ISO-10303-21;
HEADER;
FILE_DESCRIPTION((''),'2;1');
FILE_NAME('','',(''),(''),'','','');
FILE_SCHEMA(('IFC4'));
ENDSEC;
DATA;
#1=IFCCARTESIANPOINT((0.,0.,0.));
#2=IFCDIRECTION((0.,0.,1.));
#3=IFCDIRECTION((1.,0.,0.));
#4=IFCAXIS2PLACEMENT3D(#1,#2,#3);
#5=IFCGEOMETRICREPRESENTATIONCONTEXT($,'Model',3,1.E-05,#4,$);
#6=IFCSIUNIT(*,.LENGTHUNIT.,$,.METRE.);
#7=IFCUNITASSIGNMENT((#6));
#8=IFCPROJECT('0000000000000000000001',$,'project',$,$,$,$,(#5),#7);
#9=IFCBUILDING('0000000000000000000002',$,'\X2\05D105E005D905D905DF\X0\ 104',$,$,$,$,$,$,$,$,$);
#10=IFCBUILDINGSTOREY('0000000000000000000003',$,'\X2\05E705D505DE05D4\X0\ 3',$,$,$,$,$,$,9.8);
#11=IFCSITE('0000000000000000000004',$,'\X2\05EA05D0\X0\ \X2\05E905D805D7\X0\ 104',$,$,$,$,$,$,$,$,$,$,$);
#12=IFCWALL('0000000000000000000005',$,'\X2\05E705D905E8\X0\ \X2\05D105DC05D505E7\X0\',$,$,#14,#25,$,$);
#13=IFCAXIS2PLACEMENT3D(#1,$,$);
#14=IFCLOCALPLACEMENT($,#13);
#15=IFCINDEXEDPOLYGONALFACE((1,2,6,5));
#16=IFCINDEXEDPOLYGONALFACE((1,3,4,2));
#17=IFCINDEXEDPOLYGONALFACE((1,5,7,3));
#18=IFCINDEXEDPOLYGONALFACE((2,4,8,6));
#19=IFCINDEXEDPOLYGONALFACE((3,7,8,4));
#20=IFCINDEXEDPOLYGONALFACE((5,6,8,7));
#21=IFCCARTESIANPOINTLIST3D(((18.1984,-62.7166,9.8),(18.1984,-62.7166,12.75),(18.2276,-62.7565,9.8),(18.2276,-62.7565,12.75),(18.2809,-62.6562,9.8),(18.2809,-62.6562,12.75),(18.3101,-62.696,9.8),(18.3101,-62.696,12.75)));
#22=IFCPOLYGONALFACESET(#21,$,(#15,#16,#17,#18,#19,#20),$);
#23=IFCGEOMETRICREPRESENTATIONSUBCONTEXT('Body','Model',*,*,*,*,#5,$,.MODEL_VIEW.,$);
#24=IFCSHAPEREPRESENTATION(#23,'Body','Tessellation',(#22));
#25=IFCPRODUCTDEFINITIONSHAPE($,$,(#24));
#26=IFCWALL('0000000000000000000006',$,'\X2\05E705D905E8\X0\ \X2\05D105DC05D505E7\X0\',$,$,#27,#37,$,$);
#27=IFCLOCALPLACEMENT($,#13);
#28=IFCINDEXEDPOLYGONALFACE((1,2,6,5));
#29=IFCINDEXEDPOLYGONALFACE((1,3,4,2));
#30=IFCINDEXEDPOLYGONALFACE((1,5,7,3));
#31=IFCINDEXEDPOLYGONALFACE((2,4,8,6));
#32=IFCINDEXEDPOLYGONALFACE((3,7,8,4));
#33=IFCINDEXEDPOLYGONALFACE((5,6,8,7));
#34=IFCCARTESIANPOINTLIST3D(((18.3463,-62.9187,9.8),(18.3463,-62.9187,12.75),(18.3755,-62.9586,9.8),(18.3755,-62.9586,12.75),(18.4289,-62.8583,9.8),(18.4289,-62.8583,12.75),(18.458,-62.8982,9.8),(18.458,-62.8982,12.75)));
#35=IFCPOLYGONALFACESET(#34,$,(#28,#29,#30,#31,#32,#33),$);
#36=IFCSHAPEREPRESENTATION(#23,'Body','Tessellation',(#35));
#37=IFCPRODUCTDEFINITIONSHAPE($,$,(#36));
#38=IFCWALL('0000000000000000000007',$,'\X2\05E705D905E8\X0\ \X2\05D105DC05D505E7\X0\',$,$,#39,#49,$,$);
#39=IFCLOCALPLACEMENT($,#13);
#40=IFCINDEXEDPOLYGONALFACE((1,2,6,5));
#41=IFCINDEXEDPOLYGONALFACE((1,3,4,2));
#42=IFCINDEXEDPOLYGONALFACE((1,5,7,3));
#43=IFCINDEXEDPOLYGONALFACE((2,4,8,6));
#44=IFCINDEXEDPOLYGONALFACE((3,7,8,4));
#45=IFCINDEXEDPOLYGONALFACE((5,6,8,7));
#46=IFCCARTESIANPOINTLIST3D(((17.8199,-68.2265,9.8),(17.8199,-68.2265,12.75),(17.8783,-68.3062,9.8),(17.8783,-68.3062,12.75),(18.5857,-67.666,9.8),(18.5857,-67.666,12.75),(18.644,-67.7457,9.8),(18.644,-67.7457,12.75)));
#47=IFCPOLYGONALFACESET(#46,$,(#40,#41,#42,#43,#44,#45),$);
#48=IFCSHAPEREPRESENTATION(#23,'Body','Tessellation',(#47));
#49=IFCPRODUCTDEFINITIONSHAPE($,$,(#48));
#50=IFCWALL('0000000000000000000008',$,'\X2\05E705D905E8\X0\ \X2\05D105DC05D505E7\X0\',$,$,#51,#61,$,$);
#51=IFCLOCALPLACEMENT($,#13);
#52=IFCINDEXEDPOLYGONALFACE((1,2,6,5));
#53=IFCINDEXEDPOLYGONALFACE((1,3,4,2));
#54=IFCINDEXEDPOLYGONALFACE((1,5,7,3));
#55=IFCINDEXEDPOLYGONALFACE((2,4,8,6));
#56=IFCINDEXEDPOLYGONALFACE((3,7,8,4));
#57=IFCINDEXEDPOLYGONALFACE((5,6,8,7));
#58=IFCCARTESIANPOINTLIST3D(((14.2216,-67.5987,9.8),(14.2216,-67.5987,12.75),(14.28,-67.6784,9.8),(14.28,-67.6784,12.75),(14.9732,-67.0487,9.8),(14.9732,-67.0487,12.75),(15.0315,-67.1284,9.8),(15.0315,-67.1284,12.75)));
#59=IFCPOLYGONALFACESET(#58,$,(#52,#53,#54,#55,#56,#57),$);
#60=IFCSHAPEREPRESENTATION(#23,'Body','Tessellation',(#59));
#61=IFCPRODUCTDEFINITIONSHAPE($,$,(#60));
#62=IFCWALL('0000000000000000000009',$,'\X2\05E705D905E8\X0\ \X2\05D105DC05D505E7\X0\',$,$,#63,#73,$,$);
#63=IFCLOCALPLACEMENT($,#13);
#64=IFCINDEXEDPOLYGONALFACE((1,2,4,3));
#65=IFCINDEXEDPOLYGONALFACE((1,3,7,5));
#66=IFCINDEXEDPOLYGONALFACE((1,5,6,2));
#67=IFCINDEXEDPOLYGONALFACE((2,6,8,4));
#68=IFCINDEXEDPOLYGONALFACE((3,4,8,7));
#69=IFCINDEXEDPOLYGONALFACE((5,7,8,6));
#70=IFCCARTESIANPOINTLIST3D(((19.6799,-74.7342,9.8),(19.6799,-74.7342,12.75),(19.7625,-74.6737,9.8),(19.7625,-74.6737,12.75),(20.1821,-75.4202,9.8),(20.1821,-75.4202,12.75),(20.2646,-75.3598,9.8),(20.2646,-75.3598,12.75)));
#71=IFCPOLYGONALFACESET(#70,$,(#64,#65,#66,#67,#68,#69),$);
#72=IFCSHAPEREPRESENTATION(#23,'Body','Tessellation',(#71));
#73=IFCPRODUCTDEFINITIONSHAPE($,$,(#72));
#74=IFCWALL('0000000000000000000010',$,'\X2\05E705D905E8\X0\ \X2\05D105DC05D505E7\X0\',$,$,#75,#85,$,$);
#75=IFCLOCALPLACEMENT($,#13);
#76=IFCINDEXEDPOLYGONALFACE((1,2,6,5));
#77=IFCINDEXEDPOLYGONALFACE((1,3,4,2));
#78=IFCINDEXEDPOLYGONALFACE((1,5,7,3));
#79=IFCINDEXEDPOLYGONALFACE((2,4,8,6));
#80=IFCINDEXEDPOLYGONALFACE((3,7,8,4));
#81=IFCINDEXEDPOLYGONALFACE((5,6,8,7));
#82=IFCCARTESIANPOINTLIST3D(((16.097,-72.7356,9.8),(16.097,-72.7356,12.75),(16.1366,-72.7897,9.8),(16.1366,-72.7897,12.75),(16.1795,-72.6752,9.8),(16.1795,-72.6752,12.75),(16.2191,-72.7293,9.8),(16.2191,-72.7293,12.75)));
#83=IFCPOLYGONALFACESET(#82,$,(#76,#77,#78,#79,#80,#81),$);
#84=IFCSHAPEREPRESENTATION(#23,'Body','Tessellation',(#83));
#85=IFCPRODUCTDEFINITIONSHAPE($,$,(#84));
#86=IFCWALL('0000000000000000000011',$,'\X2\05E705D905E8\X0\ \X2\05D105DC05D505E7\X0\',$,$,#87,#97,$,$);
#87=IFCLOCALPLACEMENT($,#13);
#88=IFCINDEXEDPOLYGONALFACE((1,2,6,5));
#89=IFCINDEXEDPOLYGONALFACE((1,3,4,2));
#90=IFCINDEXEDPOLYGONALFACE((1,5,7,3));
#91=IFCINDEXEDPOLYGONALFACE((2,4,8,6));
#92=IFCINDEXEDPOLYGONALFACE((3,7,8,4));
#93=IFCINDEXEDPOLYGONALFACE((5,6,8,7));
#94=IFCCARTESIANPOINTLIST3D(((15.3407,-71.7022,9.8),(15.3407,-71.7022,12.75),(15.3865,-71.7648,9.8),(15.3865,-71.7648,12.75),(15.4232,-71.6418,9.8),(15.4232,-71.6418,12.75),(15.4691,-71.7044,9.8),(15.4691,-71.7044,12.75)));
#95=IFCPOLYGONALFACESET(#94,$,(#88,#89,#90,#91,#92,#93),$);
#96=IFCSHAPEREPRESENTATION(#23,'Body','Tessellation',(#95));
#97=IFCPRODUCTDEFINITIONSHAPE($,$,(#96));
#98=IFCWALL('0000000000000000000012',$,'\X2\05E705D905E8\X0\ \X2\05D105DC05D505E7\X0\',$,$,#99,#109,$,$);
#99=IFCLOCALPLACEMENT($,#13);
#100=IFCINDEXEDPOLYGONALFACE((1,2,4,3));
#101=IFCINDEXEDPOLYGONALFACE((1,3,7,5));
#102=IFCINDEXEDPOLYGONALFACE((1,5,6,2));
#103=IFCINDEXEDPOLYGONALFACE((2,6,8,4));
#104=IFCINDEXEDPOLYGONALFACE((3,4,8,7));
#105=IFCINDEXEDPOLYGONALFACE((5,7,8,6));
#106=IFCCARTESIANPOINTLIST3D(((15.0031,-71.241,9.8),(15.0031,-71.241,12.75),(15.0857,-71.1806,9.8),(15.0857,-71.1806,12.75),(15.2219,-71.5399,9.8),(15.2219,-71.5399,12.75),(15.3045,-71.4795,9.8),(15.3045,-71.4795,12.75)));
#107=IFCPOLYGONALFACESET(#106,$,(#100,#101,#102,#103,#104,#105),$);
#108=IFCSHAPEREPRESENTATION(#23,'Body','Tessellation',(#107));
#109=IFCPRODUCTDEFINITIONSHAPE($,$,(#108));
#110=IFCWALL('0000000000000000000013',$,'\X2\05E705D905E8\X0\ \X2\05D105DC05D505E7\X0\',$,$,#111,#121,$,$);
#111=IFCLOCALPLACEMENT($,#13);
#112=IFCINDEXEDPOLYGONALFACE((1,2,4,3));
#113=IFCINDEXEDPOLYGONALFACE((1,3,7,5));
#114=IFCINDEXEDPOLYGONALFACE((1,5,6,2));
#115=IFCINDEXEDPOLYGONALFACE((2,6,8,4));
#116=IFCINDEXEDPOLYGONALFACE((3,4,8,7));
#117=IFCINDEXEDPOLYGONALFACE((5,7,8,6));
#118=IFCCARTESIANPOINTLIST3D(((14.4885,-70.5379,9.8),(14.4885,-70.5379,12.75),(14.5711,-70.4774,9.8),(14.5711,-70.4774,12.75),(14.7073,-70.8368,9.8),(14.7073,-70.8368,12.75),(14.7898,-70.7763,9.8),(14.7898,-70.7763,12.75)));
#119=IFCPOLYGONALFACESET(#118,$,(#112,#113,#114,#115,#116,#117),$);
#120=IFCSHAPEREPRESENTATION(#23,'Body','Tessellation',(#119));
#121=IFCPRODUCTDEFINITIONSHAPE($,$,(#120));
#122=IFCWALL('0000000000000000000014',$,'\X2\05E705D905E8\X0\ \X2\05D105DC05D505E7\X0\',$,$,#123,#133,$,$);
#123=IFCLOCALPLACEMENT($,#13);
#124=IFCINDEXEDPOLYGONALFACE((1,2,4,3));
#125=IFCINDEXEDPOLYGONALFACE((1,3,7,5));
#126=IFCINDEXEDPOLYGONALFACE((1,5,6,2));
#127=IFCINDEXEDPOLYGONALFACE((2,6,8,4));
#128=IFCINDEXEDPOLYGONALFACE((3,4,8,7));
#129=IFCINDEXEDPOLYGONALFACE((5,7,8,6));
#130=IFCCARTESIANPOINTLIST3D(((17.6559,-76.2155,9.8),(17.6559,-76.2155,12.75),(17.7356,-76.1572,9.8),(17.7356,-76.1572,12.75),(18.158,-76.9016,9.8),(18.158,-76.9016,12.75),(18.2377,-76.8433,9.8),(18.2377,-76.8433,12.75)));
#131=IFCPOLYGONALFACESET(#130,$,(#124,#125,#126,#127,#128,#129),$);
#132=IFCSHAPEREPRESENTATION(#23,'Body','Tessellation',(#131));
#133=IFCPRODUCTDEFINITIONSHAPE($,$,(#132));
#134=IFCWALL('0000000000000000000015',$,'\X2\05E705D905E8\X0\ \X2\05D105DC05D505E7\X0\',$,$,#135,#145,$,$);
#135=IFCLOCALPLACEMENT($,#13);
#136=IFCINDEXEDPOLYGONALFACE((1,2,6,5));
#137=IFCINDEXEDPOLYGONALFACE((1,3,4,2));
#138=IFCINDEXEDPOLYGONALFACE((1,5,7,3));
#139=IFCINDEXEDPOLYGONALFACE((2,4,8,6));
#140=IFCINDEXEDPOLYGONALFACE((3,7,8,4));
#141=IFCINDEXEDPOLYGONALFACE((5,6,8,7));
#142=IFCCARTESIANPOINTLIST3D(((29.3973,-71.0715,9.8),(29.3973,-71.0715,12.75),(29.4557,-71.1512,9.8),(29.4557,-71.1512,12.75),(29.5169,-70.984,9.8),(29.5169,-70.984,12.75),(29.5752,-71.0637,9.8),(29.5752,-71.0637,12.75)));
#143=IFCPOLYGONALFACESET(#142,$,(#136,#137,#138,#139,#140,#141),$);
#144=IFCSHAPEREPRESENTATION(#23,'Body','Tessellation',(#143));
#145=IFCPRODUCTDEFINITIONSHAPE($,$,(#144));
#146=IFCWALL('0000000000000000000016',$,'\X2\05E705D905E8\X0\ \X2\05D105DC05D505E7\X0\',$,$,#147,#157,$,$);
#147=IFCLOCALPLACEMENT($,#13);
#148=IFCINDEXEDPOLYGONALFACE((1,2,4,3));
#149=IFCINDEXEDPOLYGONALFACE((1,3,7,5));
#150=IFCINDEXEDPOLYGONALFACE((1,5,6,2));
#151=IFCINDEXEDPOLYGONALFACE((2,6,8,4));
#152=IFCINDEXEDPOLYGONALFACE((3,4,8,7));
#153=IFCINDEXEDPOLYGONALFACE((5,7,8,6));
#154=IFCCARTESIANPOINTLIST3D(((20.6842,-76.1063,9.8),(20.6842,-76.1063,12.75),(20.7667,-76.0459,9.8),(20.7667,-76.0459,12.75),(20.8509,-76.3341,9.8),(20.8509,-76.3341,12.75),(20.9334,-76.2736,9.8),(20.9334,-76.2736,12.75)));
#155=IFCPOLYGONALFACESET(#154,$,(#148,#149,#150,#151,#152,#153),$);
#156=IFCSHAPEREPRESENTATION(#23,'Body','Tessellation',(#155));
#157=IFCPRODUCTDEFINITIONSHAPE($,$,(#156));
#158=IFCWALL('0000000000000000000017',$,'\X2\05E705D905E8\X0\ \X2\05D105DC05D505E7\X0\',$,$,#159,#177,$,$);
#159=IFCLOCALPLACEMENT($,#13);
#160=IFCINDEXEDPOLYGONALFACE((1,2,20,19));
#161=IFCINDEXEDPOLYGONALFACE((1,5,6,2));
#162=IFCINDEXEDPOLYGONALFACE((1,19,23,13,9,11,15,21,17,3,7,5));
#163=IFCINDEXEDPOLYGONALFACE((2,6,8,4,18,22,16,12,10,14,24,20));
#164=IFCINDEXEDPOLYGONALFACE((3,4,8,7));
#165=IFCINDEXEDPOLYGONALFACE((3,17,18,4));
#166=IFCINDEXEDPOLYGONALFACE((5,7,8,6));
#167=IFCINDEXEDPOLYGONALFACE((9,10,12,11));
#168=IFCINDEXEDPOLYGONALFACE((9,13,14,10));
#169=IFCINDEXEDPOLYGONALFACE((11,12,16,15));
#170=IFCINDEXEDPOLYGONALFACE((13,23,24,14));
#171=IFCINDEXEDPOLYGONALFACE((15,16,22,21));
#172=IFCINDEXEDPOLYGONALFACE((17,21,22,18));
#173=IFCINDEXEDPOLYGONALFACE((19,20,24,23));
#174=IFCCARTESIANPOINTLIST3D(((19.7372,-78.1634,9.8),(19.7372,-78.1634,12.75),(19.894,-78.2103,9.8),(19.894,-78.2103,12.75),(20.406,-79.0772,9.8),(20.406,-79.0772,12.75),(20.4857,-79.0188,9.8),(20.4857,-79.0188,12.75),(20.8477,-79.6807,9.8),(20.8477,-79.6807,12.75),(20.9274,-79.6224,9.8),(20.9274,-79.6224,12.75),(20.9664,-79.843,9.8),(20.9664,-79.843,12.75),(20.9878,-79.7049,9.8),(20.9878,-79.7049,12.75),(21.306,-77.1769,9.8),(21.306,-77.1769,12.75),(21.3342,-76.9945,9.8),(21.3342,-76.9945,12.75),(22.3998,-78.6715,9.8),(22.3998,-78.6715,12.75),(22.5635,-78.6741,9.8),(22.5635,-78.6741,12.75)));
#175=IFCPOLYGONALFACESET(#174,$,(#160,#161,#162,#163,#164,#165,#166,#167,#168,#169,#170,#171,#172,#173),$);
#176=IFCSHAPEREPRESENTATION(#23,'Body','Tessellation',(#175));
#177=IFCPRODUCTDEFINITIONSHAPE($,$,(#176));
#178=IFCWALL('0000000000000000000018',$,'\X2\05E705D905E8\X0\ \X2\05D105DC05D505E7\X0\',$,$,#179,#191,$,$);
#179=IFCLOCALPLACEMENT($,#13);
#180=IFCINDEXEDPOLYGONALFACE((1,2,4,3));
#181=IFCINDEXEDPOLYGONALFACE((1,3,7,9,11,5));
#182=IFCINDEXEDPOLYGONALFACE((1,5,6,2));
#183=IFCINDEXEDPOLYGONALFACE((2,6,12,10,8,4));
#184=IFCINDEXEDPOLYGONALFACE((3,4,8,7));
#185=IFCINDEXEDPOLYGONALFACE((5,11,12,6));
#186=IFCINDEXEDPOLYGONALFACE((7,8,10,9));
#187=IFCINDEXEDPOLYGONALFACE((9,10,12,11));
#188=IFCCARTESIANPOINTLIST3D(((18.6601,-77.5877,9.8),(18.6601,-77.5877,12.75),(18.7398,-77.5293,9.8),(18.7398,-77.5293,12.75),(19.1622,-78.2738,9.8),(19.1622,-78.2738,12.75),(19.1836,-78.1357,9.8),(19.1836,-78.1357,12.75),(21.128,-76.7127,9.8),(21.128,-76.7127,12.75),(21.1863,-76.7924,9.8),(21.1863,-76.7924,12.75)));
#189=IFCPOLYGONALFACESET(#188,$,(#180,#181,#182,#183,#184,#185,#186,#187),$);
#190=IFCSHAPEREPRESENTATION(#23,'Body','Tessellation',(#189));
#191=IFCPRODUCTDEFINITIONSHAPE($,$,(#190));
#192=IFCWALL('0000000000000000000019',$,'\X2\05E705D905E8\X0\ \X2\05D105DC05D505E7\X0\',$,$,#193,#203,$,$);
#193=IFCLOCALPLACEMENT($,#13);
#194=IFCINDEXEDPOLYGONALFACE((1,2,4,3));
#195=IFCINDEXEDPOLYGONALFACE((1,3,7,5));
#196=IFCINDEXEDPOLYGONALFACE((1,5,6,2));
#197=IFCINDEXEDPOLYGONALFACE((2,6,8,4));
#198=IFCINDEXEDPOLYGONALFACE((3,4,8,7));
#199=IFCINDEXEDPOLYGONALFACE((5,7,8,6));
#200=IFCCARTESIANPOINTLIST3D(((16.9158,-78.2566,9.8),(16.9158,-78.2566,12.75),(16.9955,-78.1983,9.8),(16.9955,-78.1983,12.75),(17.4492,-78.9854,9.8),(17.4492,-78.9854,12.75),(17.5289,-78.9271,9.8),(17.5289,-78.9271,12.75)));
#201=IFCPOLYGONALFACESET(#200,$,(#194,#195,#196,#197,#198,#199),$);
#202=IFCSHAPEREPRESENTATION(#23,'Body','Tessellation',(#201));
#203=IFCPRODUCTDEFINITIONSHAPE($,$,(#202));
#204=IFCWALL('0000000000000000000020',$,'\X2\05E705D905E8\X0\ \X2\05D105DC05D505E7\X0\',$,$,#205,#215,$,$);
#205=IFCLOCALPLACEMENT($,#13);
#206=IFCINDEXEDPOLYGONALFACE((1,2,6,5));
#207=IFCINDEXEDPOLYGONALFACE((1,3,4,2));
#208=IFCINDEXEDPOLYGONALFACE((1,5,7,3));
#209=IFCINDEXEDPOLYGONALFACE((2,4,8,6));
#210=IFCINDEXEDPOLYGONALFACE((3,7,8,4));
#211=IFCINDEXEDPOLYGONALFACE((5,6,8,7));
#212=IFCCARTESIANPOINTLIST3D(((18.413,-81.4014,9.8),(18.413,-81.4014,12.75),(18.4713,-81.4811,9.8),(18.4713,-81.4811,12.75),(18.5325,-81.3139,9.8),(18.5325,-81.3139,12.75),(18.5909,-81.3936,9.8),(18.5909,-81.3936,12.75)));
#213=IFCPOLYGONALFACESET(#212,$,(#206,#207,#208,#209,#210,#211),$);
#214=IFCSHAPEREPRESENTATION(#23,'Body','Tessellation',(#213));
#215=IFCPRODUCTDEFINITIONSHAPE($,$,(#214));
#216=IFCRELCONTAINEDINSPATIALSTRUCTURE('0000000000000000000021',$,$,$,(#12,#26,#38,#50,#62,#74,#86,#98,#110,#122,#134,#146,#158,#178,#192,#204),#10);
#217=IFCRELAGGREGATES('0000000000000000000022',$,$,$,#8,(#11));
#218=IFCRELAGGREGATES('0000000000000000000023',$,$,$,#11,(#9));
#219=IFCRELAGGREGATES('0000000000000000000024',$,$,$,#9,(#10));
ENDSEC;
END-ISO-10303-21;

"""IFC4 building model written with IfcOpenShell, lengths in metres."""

from ifc_helpers import new_model, si_unit, frame, origin_with_axes, context, subcontext, project, spatial, polyline, outline, extrude, element, save


model = new_model("IFC4")

# Units and contexts
model_context = context("Model", 3, precision=1e-05, world=origin_with_axes())
body_context = subcontext(model_context, "Body", "Model", "MODEL_VIEW")
ifc_project = project(units=[si_unit("LENGTHUNIT", "METRE")], contexts=[model_context])

# Site, building, storey
site = spatial("IfcSite", under=ifc_project, Name="תא שטח 104")
building = spatial("IfcBuilding", under=site, Name="בניין 104")
storey = spatial("IfcBuildingStorey", under=building, Name="קומה 3", Elevation=9.8)

# Walls
element("IfcWall", 1, inside=storey, Name="קיר בלוק", context=body_context, shape_type="SweptSolid", body=[
    extrude(outline(polyline([(18.2809, -62.6562), (18.1984, -62.7166), (18.2276, -62.7565), (18.3101, -62.696), (18.2809, -62.6562)])), frame((0.0, 0.0, 9.8)), (0.0, 0.0, 1.0), 2.95),
])
element("IfcWall", 2, inside=storey, Name="קיר בלוק", context=body_context, shape_type="SweptSolid", body=[
    extrude(outline(polyline([(18.3755, -62.9586), (18.458, -62.8982), (18.4289, -62.8583), (18.3463, -62.9187), (18.3755, -62.9586)])), frame((0.0, 0.0, 9.8)), (0.0, 0.0, 1.0), 2.95),
])
element("IfcWall", 3, inside=storey, Name="קיר בלוק", context=body_context, shape_type="SweptSolid", body=[
    extrude(outline(polyline([(18.5857, -67.666), (17.8199, -68.2265), (17.8783, -68.3062), (18.644, -67.7457), (18.5857, -67.666)])), frame((0.0, 0.0, 9.8)), (0.0, 0.0, 1.0), 2.95),
])
element("IfcWall", 4, inside=storey, Name="קיר בלוק", context=body_context, shape_type="SweptSolid", body=[
    extrude(outline(polyline([(14.2216, -67.5987), (14.28, -67.6784), (15.0315, -67.1284), (14.9732, -67.0487), (14.2216, -67.5987)])), frame((0.0, 0.0, 9.8)), (0.0, 0.0, 1.0), 2.95),
])
element("IfcWall", 5, inside=storey, Name="קיר בלוק", context=body_context, shape_type="SweptSolid", body=[
    extrude(outline(polyline([(20.1821, -75.4202), (20.2646, -75.3598), (19.7625, -74.6737), (19.6799, -74.7342), (20.1821, -75.4202)])), frame((0.0, 0.0, 9.8)), (0.0, 0.0, 1.0), 2.95),
])
element("IfcWall", 6, inside=storey, Name="קיר בלוק", context=body_context, shape_type="SweptSolid", body=[
    extrude(outline(polyline([(16.2191, -72.7293), (16.1795, -72.6752), (16.097, -72.7356), (16.1366, -72.7897), (16.2191, -72.7293)])), frame((0.0, 0.0, 9.8)), (0.0, 0.0, 1.0), 2.95),
])
element("IfcWall", 7, inside=storey, Name="קיר בלוק", context=body_context, shape_type="SweptSolid", body=[
    extrude(outline(polyline([(15.3407, -71.7022), (15.3865, -71.7648), (15.4691, -71.7044), (15.4232, -71.6418), (15.3407, -71.7022)])), frame((0.0, 0.0, 9.8)), (0.0, 0.0, 1.0), 2.95),
])
element("IfcWall", 8, inside=storey, Name="קיר בלוק", context=body_context, shape_type="SweptSolid", body=[
    extrude(outline(polyline([(15.3045, -71.4795), (15.0857, -71.1806), (15.0031, -71.241), (15.2219, -71.5399), (15.3045, -71.4795)])), frame((0.0, 0.0, 9.8)), (0.0, 0.0, 1.0), 2.95),
])
element("IfcWall", 9, inside=storey, Name="קיר בלוק", context=body_context, shape_type="SweptSolid", body=[
    extrude(outline(polyline([(14.7898, -70.7763), (14.5711, -70.4774), (14.4885, -70.5379), (14.7073, -70.8368), (14.7898, -70.7763)])), frame((0.0, 0.0, 9.8)), (0.0, 0.0, 1.0), 2.95),
])
element("IfcWall", 10, inside=storey, Name="קיר בלוק", context=body_context, shape_type="SweptSolid", body=[
    extrude(outline(polyline([(17.7356, -76.1572), (17.6559, -76.2155), (18.158, -76.9016), (18.2377, -76.8433), (17.7356, -76.1572)])), frame((0.0, 0.0, 9.8)), (0.0, 0.0, 1.0), 2.95),
])
element("IfcWall", 11, inside=storey, Name="קיר בלוק", context=body_context, shape_type="SweptSolid", body=[
    extrude(outline(polyline([(29.5752, -71.0637), (29.5169, -70.984), (29.3973, -71.0715), (29.4557, -71.1512), (29.5752, -71.0637)])), frame((0.0, 0.0, 9.8)), (0.0, 0.0, 1.0), 2.95),
])
element("IfcWall", 12, inside=storey, Name="קיר בלוק", context=body_context, shape_type="SweptSolid", body=[
    extrude(outline(polyline([(20.8509, -76.3341), (20.9334, -76.2736), (20.7667, -76.0459), (20.6842, -76.1063), (20.8509, -76.3341)])), frame((0.0, 0.0, 9.8)), (0.0, 0.0, 1.0), 2.95),
])
element("IfcWall", 13, inside=storey, Name="קיר בלוק", context=body_context, shape_type="SweptSolid", body=[
    extrude(outline(polyline([(19.7372, -78.1634), (20.406, -79.0772), (20.4857, -79.0188), (19.894, -78.2103), (21.306, -77.1769), (22.3998, -78.6715), (20.9878, -79.7049), (20.9274, -79.6224), (20.8477, -79.6807), (20.9664, -79.843), (22.5635, -78.6741), (21.3342, -76.9945), (19.7372, -78.1634)])), frame((0.0, 0.0, 9.8)), (0.0, 0.0, 1.0), 2.95),
])
element("IfcWall", 14, inside=storey, Name="קיר בלוק", context=body_context, shape_type="SweptSolid", body=[
    extrude(outline(polyline([(19.1836, -78.1357), (18.7398, -77.5293), (18.6601, -77.5877), (19.1622, -78.2738), (21.1863, -76.7924), (21.128, -76.7127), (19.1836, -78.1357)])), frame((0.0, 0.0, 9.8)), (0.0, 0.0, 1.0), 2.95),
])
element("IfcWall", 15, inside=storey, Name="קיר בלוק", context=body_context, shape_type="SweptSolid", body=[
    extrude(outline(polyline([(16.9955, -78.1983), (16.9158, -78.2566), (17.4492, -78.9854), (17.5289, -78.9271), (16.9955, -78.1983)])), frame((0.0, 0.0, 9.8)), (0.0, 0.0, 1.0), 2.95),
])
element("IfcWall", 16, inside=storey, Name="קיר בלוק", context=body_context, shape_type="SweptSolid", body=[
    extrude(outline(polyline([(18.5909, -81.3936), (18.5325, -81.3139), (18.413, -81.4014), (18.4713, -81.4811), (18.5909, -81.3936)])), frame((0.0, 0.0, 9.8)), (0.0, 0.0, 1.0), 2.95),
])

save(model, "model.ifc")
